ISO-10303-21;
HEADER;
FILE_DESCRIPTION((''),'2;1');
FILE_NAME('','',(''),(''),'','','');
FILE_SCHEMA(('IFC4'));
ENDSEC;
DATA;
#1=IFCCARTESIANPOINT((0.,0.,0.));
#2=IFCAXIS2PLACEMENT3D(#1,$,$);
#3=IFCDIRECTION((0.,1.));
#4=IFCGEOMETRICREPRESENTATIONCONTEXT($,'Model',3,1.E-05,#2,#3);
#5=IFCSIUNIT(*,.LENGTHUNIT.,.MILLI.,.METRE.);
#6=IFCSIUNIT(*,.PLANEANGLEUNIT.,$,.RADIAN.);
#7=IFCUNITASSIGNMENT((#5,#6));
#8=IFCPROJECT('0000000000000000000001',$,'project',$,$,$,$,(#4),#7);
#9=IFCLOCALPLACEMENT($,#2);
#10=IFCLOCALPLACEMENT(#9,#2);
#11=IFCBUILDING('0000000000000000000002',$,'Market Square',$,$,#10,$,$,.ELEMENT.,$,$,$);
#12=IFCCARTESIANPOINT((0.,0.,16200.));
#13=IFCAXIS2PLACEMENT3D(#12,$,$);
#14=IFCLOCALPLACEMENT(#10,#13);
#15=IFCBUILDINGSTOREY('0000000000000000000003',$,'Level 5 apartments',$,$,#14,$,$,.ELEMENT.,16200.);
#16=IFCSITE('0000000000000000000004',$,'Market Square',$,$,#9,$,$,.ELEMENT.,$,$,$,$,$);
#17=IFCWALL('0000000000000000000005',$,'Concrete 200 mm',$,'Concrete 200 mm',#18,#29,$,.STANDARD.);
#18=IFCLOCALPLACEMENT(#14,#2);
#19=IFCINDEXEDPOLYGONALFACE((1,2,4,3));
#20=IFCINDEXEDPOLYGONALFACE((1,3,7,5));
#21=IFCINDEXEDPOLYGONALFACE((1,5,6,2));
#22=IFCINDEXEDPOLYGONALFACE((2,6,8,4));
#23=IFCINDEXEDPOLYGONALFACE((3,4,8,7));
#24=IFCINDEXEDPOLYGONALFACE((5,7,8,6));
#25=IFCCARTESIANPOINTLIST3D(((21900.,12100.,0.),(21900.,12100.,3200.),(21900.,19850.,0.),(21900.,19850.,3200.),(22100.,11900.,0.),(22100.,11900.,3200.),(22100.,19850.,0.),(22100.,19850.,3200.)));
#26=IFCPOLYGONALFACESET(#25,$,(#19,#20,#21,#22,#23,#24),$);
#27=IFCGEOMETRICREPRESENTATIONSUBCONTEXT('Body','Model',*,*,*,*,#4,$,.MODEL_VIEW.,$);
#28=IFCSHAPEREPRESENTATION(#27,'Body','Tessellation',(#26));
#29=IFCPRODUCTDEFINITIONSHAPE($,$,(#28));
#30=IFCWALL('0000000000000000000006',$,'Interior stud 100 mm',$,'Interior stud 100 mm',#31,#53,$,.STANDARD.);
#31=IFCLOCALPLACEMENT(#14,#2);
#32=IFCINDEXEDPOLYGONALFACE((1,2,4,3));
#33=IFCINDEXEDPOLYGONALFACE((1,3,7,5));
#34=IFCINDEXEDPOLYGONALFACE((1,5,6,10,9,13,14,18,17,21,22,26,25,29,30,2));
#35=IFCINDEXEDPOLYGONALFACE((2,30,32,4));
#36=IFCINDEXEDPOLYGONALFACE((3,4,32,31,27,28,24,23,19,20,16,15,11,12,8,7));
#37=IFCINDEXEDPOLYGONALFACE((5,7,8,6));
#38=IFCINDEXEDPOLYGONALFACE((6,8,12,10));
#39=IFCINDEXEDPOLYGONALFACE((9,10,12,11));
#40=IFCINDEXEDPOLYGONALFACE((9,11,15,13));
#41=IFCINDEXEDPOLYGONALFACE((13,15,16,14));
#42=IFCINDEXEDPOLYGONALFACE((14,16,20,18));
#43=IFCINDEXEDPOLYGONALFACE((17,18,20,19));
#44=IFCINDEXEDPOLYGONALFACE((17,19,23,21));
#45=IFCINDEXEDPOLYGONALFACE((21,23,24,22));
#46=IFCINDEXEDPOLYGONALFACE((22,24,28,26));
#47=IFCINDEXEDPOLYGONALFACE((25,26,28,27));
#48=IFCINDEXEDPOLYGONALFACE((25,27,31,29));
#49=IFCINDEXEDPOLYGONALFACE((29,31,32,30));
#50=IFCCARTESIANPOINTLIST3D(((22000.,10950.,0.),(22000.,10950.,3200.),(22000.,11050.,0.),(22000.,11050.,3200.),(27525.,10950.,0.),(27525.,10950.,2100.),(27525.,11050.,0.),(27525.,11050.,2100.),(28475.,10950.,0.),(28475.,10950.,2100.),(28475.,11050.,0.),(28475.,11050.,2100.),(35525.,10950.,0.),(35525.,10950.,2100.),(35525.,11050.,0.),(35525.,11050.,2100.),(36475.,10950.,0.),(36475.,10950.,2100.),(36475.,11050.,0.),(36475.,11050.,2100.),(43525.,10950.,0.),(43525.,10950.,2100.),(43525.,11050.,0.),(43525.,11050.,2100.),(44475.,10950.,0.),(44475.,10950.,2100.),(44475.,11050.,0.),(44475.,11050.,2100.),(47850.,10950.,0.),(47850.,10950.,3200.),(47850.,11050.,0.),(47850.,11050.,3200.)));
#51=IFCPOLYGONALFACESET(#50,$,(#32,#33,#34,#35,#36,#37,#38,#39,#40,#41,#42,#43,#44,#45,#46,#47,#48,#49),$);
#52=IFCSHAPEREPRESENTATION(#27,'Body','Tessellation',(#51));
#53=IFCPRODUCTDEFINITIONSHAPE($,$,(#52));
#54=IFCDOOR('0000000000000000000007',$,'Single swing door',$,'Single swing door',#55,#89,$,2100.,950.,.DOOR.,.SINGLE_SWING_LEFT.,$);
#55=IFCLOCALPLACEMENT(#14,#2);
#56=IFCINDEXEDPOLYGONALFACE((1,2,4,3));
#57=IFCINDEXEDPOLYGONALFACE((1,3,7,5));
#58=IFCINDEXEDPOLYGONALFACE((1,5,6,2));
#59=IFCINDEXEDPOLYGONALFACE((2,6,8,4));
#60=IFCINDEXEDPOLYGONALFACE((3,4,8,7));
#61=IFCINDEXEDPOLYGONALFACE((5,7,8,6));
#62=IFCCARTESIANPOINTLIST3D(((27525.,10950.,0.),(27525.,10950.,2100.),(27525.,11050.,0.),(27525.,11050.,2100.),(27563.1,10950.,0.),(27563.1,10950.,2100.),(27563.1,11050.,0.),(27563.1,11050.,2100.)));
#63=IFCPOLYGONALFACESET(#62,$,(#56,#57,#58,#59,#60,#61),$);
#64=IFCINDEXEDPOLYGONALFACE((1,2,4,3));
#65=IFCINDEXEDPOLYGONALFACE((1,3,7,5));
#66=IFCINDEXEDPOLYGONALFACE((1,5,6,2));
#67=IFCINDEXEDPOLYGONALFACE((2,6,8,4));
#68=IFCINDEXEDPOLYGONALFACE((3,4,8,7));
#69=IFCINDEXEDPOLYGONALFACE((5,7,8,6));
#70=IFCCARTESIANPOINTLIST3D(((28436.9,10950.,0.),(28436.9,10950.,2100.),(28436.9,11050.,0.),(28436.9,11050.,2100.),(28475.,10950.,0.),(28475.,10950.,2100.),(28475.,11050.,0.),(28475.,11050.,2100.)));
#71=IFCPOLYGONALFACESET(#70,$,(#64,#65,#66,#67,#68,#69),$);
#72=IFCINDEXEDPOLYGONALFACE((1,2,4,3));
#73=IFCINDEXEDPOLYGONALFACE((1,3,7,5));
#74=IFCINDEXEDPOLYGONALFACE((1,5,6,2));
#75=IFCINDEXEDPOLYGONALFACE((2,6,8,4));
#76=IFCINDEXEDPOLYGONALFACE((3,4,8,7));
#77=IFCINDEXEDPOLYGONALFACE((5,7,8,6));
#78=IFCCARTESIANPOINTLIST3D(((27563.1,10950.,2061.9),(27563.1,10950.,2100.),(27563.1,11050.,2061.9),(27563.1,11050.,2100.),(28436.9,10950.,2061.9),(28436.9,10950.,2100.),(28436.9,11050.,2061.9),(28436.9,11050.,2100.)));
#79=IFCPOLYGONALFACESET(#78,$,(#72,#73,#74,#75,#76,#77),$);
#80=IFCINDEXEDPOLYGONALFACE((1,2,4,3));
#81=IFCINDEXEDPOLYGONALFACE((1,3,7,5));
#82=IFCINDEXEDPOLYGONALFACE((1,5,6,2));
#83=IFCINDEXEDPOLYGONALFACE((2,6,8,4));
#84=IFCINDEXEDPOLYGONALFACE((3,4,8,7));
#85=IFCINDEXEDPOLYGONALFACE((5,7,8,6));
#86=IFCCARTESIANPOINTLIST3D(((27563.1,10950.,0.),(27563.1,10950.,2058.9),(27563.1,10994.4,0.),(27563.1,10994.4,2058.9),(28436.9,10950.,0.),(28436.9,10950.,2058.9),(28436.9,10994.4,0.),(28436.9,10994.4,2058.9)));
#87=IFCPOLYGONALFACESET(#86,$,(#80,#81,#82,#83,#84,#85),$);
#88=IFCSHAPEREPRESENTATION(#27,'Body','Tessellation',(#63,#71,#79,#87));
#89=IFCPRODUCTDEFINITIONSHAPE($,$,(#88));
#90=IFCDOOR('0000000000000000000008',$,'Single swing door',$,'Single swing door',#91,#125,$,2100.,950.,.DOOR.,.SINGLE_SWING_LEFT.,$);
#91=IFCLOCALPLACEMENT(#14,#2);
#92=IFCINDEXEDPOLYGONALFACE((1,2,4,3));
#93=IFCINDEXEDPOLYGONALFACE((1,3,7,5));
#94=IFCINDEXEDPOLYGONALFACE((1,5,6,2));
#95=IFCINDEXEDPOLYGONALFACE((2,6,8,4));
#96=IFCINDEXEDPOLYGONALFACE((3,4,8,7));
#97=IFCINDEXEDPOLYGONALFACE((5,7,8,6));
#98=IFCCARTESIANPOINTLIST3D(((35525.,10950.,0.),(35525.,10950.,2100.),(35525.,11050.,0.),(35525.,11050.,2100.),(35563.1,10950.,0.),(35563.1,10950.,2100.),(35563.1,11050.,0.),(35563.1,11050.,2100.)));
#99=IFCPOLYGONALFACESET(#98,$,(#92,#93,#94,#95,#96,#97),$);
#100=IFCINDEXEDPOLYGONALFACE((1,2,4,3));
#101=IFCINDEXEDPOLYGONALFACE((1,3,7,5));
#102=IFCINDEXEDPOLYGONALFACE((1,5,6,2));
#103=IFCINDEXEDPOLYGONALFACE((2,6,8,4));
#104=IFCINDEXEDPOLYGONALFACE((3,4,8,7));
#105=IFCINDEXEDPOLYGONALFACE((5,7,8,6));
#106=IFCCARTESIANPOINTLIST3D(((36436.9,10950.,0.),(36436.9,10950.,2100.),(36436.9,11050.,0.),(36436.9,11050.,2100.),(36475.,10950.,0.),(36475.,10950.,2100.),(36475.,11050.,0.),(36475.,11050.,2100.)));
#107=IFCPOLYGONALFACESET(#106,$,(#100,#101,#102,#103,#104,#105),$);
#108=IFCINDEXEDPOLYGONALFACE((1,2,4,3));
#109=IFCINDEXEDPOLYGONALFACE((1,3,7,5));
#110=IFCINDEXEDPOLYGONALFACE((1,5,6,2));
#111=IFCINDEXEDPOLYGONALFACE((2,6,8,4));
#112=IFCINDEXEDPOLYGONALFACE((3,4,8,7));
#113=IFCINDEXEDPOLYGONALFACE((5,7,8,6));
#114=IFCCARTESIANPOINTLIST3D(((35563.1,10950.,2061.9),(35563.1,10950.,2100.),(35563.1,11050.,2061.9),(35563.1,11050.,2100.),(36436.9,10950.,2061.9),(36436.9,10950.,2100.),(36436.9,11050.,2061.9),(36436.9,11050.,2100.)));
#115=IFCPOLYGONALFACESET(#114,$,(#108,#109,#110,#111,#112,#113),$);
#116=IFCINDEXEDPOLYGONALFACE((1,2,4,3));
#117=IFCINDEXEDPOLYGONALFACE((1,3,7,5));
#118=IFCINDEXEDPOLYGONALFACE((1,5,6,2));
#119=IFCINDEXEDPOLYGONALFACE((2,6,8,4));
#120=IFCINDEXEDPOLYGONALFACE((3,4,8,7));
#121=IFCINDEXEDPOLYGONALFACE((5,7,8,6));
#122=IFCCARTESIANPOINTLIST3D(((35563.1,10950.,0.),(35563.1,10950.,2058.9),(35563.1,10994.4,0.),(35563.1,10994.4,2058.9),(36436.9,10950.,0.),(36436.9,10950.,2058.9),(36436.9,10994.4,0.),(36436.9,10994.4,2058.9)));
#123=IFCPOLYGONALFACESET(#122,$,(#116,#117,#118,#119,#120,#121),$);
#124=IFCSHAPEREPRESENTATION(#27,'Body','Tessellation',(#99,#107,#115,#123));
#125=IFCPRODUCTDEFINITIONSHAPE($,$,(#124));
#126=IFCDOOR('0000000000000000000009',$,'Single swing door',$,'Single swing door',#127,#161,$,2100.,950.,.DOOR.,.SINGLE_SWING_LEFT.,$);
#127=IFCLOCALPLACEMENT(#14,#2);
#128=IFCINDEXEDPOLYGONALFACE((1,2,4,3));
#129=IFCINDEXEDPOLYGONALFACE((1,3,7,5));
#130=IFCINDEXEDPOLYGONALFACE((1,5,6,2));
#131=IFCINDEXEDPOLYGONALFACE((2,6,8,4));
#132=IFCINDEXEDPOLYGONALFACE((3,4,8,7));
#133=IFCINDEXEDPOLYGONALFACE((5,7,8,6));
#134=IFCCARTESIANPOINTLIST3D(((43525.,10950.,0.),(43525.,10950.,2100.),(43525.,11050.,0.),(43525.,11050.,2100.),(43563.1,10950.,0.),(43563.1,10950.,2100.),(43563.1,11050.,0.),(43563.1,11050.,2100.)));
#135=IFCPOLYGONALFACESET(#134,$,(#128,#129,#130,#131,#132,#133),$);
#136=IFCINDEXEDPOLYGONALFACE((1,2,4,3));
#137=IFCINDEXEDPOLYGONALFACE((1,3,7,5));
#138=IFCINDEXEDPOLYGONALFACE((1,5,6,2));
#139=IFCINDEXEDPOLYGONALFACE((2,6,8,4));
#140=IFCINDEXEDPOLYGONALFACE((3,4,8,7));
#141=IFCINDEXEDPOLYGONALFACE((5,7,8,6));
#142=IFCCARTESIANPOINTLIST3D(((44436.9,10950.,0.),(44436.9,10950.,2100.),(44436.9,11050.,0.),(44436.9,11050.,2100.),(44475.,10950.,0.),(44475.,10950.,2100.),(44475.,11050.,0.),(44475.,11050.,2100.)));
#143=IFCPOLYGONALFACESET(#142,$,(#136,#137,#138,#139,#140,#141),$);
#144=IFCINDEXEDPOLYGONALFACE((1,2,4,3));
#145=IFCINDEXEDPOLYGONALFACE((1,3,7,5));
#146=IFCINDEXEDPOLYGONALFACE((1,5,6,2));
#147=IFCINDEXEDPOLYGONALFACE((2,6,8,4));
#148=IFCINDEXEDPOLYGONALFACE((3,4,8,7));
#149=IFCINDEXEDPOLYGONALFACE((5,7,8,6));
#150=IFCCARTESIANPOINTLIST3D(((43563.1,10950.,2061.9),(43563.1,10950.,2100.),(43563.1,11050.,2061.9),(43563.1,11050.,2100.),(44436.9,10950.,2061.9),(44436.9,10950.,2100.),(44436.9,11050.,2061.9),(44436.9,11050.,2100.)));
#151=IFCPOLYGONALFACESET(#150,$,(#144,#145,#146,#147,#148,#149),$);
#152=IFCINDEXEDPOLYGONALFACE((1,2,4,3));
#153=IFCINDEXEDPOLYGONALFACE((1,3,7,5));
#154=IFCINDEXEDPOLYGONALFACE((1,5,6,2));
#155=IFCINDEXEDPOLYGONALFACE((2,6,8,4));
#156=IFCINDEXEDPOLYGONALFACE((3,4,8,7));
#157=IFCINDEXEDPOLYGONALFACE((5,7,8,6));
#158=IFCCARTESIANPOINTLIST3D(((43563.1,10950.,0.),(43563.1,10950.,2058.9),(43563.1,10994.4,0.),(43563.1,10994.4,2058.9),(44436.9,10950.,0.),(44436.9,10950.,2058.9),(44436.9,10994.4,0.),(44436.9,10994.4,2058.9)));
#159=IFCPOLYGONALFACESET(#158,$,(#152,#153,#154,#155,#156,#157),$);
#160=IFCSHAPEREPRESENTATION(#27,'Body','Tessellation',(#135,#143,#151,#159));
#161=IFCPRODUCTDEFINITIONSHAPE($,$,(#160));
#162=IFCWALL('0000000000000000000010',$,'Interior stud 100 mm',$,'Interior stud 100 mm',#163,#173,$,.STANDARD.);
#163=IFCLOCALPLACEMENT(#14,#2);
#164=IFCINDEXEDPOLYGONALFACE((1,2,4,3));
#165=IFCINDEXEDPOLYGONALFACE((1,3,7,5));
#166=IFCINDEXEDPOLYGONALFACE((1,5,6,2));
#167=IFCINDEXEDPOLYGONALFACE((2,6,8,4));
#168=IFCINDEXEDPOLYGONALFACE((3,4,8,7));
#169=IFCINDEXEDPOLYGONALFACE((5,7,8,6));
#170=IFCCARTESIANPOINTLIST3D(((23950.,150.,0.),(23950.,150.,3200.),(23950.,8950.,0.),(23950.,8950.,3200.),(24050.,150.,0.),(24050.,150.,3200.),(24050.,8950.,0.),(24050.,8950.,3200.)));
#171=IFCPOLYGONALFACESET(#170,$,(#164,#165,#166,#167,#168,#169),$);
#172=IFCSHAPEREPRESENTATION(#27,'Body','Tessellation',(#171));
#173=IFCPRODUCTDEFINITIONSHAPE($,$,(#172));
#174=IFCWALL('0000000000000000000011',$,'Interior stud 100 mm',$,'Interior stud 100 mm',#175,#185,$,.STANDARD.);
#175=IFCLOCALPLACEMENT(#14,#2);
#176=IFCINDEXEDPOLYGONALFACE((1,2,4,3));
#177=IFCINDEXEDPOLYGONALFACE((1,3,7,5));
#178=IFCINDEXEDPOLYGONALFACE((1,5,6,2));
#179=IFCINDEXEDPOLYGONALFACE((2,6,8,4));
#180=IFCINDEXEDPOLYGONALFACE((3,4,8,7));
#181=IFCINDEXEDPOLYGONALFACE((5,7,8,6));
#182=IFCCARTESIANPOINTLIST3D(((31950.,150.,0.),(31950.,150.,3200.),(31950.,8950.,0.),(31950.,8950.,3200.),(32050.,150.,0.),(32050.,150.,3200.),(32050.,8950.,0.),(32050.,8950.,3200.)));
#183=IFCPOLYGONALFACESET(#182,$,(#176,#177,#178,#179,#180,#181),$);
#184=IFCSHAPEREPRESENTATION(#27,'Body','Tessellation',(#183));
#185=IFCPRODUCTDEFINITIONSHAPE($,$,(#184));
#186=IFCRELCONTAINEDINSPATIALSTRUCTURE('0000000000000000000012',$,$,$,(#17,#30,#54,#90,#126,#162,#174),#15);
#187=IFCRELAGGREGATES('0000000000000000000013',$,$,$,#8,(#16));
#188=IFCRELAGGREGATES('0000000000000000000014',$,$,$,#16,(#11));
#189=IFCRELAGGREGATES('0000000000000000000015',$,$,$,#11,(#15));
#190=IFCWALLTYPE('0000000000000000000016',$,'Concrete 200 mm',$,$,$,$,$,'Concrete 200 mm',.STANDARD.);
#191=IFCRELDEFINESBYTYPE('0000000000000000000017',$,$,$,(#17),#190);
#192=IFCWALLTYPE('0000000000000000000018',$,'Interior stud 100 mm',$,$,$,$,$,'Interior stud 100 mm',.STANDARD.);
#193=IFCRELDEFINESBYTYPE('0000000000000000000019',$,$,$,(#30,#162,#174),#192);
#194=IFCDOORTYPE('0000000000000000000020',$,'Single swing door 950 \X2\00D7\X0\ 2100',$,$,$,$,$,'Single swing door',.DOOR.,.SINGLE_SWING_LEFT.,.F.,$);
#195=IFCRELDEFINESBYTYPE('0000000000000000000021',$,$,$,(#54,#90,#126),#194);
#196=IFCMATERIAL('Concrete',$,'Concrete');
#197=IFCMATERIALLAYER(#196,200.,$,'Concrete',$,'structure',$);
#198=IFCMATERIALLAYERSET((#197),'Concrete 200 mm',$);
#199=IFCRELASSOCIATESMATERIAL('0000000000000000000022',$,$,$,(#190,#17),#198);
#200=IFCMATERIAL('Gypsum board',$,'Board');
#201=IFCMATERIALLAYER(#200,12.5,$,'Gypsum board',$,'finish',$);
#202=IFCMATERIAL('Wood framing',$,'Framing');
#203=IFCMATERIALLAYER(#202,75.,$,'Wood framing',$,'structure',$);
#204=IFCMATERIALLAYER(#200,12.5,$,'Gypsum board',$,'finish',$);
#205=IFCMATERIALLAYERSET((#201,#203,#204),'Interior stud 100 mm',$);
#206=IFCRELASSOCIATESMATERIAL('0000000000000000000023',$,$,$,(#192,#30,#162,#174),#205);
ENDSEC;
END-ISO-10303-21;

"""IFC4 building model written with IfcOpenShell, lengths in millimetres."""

from ifc_helpers import new_model, si_unit, direction, frame, origin, origin_with_axes, place, context, subcontext, project, spatial, polyline, outline, extrude, material, layer, layer_set, layer_usage, type_object, element, fill, save


model = new_model("IFC4")

# Units and contexts
model_context = context("Model", 3, precision=1e-05, world=origin(), true_north=direction((0.0, 1.0)))
body_context = subcontext(model_context, "Body", "Model", "MODEL_VIEW")
ifc_project = project(units=[si_unit("LENGTHUNIT", "METRE", prefix="MILLI"), si_unit("PLANEANGLEUNIT", "RADIAN")], contexts=[model_context])

# Site, building, storey
site_placement = place(None, origin())
site = spatial("IfcSite", under=ifc_project, at=site_placement, Name="Market Square", CompositionType="ELEMENT")
building_placement = place(site_placement, origin())
building = spatial("IfcBuilding", under=site, at=building_placement, Name="Market Square", CompositionType="ELEMENT")
storey_placement = place(building_placement, frame((0.0, 0.0, 16200.0)))
storey = spatial("IfcBuildingStorey", under=building, at=storey_placement, Name="Level 5 apartments", CompositionType="ELEMENT", Elevation=16200.0)

# Wall
ifc_material_1 = material(Name="Concrete", Category="Concrete")
ifc_layer_1 = layer(ifc_material_1, 200.0, Name="Concrete", Category="structure")
ifc_layer_set_1 = layer_set([ifc_layer_1], Name="Concrete 200 mm")
ifc_layer_usage_1 = layer_usage(ifc_layer_set_1, "AXIS2", "NEGATIVE", 100.0)
wall_type_1 = type_object("IfcWallType", Name="Concrete 200 mm", ElementType="Concrete 200 mm", PredefinedType="STANDARD", material=ifc_layer_set_1)
wall_1_placement = place(storey_placement, frame((22000.0, 12000.0, 0.0), z_axis=(0.0, 0.0, 1.0), x_axis=(0.0, 1.0, 0.0)))
element("IfcWall", 1, at=wall_1_placement, inside=storey, type_object=wall_type_1, material=ifc_layer_usage_1, Name="Concrete 200 mm", ObjectType="Concrete 200 mm", PredefinedType="STANDARD", context=body_context, shape_type="SweptSolid", body=[
    extrude(outline(polyline([(-100.0, -100.0), (7850.0, -100.0), (7850.0, 100.0), (100.0, 100.0), (-100.0, -100.0)])), origin(), (0.0, 0.0, 1.0), 3200.0),
])

# Wall, openings, doors
ifc_material_2 = material(Name="Gypsum board", Category="Board")
ifc_layer_2 = layer(ifc_material_2, 12.5, Name="Gypsum board", Category="finish")
ifc_material_3 = material(Name="Wood framing", Category="Framing")
ifc_layer_3 = layer(ifc_material_3, 75.0, Name="Wood framing", Category="structure")
ifc_layer_4 = layer(ifc_material_2, 12.5, Name="Gypsum board", Category="finish")
ifc_layer_set_2 = layer_set([ifc_layer_2, ifc_layer_3, ifc_layer_4], Name="Interior stud 100 mm")
ifc_layer_usage_2 = layer_usage(ifc_layer_set_2, "AXIS2", "NEGATIVE", 50.0)
wall_type_2 = type_object("IfcWallType", Name="Interior stud 100 mm", ElementType="Interior stud 100 mm", PredefinedType="STANDARD", material=ifc_layer_set_2)
wall_2_placement = place(storey_placement, frame((22000.0, 11000.0, 0.0), z_axis=(0.0, 0.0, 1.0), x_axis=(1.0, 0.0, 0.0)))
wall_2 = element("IfcWall", 2, at=wall_2_placement, inside=storey, type_object=wall_type_2, material=ifc_layer_usage_2, Name="Interior stud 100 mm", ObjectType="Interior stud 100 mm", PredefinedType="STANDARD", context=body_context, shape_type="SweptSolid", body=[
    extrude(outline(polyline([(0.0, -50.0), (25850.0, -50.0), (25850.0, 50.0), (0.0, 50.0), (0.0, -50.0)])), origin(), (0.0, 0.0, 1.0), 3200.0),
])
opening_1_placement = place(wall_2_placement, frame((5525.0, 0.0, 0.0), z_axis=(0.0, 0.0, 1.0), x_axis=(1.0, 0.0, 0.0)))
opening_1 = element("IfcOpeningElement", 3, at=opening_1_placement, cuts=wall_2, PredefinedType="OPENING", context=body_context, shape_type="SweptSolid", body=[
    extrude(outline(polyline([(0.0, -60.0), (950.0, -60.0), (950.0, 60.0), (0.0, 60.0), (0.0, -60.0)])), origin(), (0.0, 0.0, 1.0), 2100.0),
])
opening_2_placement = place(wall_2_placement, frame((13525.0, 0.0, 0.0), z_axis=(0.0, 0.0, 1.0), x_axis=(1.0, 0.0, 0.0)))
opening_2 = element("IfcOpeningElement", 4, at=opening_2_placement, cuts=wall_2, PredefinedType="OPENING", context=body_context, shape_type="SweptSolid", body=[
    extrude(outline(polyline([(0.0, -60.0), (950.0, -60.0), (950.0, 60.0), (0.0, 60.0), (0.0, -60.0)])), origin(), (0.0, 0.0, 1.0), 2100.0),
])
opening_3_placement = place(wall_2_placement, frame((21525.0, 0.0, 0.0), z_axis=(0.0, 0.0, 1.0), x_axis=(1.0, 0.0, 0.0)))
opening_3 = element("IfcOpeningElement", 5, at=opening_3_placement, cuts=wall_2, PredefinedType="OPENING", context=body_context, shape_type="SweptSolid", body=[
    extrude(outline(polyline([(0.0, -60.0), (950.0, -60.0), (950.0, 60.0), (0.0, 60.0), (0.0, -60.0)])), origin(), (0.0, 0.0, 1.0), 2100.0),
])
door_type = type_object("IfcDoorType", Name="Single swing door 950 × 2100", ElementType="Single swing door", OperationType="SINGLE_SWING_LEFT", ParameterTakesPrecedence=False, PredefinedType="DOOR")
door_1_placement = place(opening_1_placement, origin_with_axes())
door_1 = element("IfcDoor", 6, at=door_1_placement, inside=storey, type_object=door_type, Name="Single swing door", ObjectType="Single swing door", OperationType="SINGLE_SWING_LEFT", OverallHeight=2100.0, OverallWidth=950.0, PredefinedType="DOOR", context=body_context, shape_type="SweptSolid", body=[
    extrude(outline(polyline([(0.0, -50.0), (38.1, -50.0), (38.1, 50.0), (0.0, 50.0), (0.0, -50.0)])), origin(), (0.0, 0.0, 1.0), 2100.0),
    extrude(outline(polyline([(911.9, -50.0), (950.0, -50.0), (950.0, 50.0), (911.9, 50.0), (911.9, -50.0)])), origin(), (0.0, 0.0, 1.0), 2100.0),
    extrude(outline(polyline([(38.1, -50.0), (911.9, -50.0), (911.9, 50.0), (38.1, 50.0), (38.1, -50.0)])), frame((0.0, 0.0, 2061.9)), (0.0, 0.0, 1.0), 38.1),
    extrude(outline(polyline([(38.1, -50.0), (911.9, -50.0), (911.9, -5.5), (38.1, -5.5), (38.1, -50.0)])), origin(), (0.0, 0.0, 1.0), 2058.9),
])
fill(opening_1, door_1)
door_2_placement = place(opening_2_placement, origin_with_axes())
door_2 = element("IfcDoor", 7, at=door_2_placement, inside=storey, type_object=door_type, Name="Single swing door", ObjectType="Single swing door", OperationType="SINGLE_SWING_LEFT", OverallHeight=2100.0, OverallWidth=950.0, PredefinedType="DOOR", context=body_context, shape_type="SweptSolid", body=[
    extrude(outline(polyline([(0.0, -50.0), (38.1, -50.0), (38.1, 50.0), (0.0, 50.0), (0.0, -50.0)])), origin(), (0.0, 0.0, 1.0), 2100.0),
    extrude(outline(polyline([(911.9, -50.0), (950.0, -50.0), (950.0, 50.0), (911.9, 50.0), (911.9, -50.0)])), origin(), (0.0, 0.0, 1.0), 2100.0),
    extrude(outline(polyline([(38.1, -50.0), (911.9, -50.0), (911.9, 50.0), (38.1, 50.0), (38.1, -50.0)])), frame((0.0, 0.0, 2061.9)), (0.0, 0.0, 1.0), 38.1),
    extrude(outline(polyline([(38.1, -50.0), (911.9, -50.0), (911.9, -5.5), (38.1, -5.5), (38.1, -50.0)])), origin(), (0.0, 0.0, 1.0), 2058.9),
])
fill(opening_2, door_2)
door_3_placement = place(opening_3_placement, origin_with_axes())
door_3 = element("IfcDoor", 8, at=door_3_placement, inside=storey, type_object=door_type, Name="Single swing door", ObjectType="Single swing door", OperationType="SINGLE_SWING_LEFT", OverallHeight=2100.0, OverallWidth=950.0, PredefinedType="DOOR", context=body_context, shape_type="SweptSolid", body=[
    extrude(outline(polyline([(0.0, -50.0), (38.1, -50.0), (38.1, 50.0), (0.0, 50.0), (0.0, -50.0)])), origin(), (0.0, 0.0, 1.0), 2100.0),
    extrude(outline(polyline([(911.9, -50.0), (950.0, -50.0), (950.0, 50.0), (911.9, 50.0), (911.9, -50.0)])), origin(), (0.0, 0.0, 1.0), 2100.0),
    extrude(outline(polyline([(38.1, -50.0), (911.9, -50.0), (911.9, 50.0), (38.1, 50.0), (38.1, -50.0)])), frame((0.0, 0.0, 2061.9)), (0.0, 0.0, 1.0), 38.1),
    extrude(outline(polyline([(38.1, -50.0), (911.9, -50.0), (911.9, -5.5), (38.1, -5.5), (38.1, -50.0)])), origin(), (0.0, 0.0, 1.0), 2058.9),
])
fill(opening_3, door_3)

# Walls
ifc_layer_usage_3 = layer_usage(ifc_layer_set_2, "AXIS2", "NEGATIVE", 50.0)
wall_3_placement = place(storey_placement, frame((24000.0, 0.0, 0.0), z_axis=(0.0, 0.0, 1.0), x_axis=(0.0, 1.0, 0.0)))
element("IfcWall", 9, at=wall_3_placement, inside=storey, type_object=wall_type_2, material=ifc_layer_usage_3, Name="Interior stud 100 mm", ObjectType="Interior stud 100 mm", PredefinedType="STANDARD", context=body_context, shape_type="SweptSolid", body=[
    extrude(outline(polyline([(150.0, -50.0), (8950.0, -50.0), (8950.0, 50.0), (150.0, 50.0), (150.0, -50.0)])), origin(), (0.0, 0.0, 1.0), 3200.0),
])
ifc_layer_usage_4 = layer_usage(ifc_layer_set_2, "AXIS2", "NEGATIVE", 50.0)
wall_4_placement = place(storey_placement, frame((32000.0, 0.0, 0.0), z_axis=(0.0, 0.0, 1.0), x_axis=(0.0, 1.0, 0.0)))
element("IfcWall", 10, at=wall_4_placement, inside=storey, type_object=wall_type_2, material=ifc_layer_usage_4, Name="Interior stud 100 mm", ObjectType="Interior stud 100 mm", PredefinedType="STANDARD", context=body_context, shape_type="SweptSolid", body=[
    extrude(outline(polyline([(150.0, -50.0), (8950.0, -50.0), (8950.0, 50.0), (150.0, 50.0), (150.0, -50.0)])), origin(), (0.0, 0.0, 1.0), 3200.0),
])

save(model, "model.ifc")
